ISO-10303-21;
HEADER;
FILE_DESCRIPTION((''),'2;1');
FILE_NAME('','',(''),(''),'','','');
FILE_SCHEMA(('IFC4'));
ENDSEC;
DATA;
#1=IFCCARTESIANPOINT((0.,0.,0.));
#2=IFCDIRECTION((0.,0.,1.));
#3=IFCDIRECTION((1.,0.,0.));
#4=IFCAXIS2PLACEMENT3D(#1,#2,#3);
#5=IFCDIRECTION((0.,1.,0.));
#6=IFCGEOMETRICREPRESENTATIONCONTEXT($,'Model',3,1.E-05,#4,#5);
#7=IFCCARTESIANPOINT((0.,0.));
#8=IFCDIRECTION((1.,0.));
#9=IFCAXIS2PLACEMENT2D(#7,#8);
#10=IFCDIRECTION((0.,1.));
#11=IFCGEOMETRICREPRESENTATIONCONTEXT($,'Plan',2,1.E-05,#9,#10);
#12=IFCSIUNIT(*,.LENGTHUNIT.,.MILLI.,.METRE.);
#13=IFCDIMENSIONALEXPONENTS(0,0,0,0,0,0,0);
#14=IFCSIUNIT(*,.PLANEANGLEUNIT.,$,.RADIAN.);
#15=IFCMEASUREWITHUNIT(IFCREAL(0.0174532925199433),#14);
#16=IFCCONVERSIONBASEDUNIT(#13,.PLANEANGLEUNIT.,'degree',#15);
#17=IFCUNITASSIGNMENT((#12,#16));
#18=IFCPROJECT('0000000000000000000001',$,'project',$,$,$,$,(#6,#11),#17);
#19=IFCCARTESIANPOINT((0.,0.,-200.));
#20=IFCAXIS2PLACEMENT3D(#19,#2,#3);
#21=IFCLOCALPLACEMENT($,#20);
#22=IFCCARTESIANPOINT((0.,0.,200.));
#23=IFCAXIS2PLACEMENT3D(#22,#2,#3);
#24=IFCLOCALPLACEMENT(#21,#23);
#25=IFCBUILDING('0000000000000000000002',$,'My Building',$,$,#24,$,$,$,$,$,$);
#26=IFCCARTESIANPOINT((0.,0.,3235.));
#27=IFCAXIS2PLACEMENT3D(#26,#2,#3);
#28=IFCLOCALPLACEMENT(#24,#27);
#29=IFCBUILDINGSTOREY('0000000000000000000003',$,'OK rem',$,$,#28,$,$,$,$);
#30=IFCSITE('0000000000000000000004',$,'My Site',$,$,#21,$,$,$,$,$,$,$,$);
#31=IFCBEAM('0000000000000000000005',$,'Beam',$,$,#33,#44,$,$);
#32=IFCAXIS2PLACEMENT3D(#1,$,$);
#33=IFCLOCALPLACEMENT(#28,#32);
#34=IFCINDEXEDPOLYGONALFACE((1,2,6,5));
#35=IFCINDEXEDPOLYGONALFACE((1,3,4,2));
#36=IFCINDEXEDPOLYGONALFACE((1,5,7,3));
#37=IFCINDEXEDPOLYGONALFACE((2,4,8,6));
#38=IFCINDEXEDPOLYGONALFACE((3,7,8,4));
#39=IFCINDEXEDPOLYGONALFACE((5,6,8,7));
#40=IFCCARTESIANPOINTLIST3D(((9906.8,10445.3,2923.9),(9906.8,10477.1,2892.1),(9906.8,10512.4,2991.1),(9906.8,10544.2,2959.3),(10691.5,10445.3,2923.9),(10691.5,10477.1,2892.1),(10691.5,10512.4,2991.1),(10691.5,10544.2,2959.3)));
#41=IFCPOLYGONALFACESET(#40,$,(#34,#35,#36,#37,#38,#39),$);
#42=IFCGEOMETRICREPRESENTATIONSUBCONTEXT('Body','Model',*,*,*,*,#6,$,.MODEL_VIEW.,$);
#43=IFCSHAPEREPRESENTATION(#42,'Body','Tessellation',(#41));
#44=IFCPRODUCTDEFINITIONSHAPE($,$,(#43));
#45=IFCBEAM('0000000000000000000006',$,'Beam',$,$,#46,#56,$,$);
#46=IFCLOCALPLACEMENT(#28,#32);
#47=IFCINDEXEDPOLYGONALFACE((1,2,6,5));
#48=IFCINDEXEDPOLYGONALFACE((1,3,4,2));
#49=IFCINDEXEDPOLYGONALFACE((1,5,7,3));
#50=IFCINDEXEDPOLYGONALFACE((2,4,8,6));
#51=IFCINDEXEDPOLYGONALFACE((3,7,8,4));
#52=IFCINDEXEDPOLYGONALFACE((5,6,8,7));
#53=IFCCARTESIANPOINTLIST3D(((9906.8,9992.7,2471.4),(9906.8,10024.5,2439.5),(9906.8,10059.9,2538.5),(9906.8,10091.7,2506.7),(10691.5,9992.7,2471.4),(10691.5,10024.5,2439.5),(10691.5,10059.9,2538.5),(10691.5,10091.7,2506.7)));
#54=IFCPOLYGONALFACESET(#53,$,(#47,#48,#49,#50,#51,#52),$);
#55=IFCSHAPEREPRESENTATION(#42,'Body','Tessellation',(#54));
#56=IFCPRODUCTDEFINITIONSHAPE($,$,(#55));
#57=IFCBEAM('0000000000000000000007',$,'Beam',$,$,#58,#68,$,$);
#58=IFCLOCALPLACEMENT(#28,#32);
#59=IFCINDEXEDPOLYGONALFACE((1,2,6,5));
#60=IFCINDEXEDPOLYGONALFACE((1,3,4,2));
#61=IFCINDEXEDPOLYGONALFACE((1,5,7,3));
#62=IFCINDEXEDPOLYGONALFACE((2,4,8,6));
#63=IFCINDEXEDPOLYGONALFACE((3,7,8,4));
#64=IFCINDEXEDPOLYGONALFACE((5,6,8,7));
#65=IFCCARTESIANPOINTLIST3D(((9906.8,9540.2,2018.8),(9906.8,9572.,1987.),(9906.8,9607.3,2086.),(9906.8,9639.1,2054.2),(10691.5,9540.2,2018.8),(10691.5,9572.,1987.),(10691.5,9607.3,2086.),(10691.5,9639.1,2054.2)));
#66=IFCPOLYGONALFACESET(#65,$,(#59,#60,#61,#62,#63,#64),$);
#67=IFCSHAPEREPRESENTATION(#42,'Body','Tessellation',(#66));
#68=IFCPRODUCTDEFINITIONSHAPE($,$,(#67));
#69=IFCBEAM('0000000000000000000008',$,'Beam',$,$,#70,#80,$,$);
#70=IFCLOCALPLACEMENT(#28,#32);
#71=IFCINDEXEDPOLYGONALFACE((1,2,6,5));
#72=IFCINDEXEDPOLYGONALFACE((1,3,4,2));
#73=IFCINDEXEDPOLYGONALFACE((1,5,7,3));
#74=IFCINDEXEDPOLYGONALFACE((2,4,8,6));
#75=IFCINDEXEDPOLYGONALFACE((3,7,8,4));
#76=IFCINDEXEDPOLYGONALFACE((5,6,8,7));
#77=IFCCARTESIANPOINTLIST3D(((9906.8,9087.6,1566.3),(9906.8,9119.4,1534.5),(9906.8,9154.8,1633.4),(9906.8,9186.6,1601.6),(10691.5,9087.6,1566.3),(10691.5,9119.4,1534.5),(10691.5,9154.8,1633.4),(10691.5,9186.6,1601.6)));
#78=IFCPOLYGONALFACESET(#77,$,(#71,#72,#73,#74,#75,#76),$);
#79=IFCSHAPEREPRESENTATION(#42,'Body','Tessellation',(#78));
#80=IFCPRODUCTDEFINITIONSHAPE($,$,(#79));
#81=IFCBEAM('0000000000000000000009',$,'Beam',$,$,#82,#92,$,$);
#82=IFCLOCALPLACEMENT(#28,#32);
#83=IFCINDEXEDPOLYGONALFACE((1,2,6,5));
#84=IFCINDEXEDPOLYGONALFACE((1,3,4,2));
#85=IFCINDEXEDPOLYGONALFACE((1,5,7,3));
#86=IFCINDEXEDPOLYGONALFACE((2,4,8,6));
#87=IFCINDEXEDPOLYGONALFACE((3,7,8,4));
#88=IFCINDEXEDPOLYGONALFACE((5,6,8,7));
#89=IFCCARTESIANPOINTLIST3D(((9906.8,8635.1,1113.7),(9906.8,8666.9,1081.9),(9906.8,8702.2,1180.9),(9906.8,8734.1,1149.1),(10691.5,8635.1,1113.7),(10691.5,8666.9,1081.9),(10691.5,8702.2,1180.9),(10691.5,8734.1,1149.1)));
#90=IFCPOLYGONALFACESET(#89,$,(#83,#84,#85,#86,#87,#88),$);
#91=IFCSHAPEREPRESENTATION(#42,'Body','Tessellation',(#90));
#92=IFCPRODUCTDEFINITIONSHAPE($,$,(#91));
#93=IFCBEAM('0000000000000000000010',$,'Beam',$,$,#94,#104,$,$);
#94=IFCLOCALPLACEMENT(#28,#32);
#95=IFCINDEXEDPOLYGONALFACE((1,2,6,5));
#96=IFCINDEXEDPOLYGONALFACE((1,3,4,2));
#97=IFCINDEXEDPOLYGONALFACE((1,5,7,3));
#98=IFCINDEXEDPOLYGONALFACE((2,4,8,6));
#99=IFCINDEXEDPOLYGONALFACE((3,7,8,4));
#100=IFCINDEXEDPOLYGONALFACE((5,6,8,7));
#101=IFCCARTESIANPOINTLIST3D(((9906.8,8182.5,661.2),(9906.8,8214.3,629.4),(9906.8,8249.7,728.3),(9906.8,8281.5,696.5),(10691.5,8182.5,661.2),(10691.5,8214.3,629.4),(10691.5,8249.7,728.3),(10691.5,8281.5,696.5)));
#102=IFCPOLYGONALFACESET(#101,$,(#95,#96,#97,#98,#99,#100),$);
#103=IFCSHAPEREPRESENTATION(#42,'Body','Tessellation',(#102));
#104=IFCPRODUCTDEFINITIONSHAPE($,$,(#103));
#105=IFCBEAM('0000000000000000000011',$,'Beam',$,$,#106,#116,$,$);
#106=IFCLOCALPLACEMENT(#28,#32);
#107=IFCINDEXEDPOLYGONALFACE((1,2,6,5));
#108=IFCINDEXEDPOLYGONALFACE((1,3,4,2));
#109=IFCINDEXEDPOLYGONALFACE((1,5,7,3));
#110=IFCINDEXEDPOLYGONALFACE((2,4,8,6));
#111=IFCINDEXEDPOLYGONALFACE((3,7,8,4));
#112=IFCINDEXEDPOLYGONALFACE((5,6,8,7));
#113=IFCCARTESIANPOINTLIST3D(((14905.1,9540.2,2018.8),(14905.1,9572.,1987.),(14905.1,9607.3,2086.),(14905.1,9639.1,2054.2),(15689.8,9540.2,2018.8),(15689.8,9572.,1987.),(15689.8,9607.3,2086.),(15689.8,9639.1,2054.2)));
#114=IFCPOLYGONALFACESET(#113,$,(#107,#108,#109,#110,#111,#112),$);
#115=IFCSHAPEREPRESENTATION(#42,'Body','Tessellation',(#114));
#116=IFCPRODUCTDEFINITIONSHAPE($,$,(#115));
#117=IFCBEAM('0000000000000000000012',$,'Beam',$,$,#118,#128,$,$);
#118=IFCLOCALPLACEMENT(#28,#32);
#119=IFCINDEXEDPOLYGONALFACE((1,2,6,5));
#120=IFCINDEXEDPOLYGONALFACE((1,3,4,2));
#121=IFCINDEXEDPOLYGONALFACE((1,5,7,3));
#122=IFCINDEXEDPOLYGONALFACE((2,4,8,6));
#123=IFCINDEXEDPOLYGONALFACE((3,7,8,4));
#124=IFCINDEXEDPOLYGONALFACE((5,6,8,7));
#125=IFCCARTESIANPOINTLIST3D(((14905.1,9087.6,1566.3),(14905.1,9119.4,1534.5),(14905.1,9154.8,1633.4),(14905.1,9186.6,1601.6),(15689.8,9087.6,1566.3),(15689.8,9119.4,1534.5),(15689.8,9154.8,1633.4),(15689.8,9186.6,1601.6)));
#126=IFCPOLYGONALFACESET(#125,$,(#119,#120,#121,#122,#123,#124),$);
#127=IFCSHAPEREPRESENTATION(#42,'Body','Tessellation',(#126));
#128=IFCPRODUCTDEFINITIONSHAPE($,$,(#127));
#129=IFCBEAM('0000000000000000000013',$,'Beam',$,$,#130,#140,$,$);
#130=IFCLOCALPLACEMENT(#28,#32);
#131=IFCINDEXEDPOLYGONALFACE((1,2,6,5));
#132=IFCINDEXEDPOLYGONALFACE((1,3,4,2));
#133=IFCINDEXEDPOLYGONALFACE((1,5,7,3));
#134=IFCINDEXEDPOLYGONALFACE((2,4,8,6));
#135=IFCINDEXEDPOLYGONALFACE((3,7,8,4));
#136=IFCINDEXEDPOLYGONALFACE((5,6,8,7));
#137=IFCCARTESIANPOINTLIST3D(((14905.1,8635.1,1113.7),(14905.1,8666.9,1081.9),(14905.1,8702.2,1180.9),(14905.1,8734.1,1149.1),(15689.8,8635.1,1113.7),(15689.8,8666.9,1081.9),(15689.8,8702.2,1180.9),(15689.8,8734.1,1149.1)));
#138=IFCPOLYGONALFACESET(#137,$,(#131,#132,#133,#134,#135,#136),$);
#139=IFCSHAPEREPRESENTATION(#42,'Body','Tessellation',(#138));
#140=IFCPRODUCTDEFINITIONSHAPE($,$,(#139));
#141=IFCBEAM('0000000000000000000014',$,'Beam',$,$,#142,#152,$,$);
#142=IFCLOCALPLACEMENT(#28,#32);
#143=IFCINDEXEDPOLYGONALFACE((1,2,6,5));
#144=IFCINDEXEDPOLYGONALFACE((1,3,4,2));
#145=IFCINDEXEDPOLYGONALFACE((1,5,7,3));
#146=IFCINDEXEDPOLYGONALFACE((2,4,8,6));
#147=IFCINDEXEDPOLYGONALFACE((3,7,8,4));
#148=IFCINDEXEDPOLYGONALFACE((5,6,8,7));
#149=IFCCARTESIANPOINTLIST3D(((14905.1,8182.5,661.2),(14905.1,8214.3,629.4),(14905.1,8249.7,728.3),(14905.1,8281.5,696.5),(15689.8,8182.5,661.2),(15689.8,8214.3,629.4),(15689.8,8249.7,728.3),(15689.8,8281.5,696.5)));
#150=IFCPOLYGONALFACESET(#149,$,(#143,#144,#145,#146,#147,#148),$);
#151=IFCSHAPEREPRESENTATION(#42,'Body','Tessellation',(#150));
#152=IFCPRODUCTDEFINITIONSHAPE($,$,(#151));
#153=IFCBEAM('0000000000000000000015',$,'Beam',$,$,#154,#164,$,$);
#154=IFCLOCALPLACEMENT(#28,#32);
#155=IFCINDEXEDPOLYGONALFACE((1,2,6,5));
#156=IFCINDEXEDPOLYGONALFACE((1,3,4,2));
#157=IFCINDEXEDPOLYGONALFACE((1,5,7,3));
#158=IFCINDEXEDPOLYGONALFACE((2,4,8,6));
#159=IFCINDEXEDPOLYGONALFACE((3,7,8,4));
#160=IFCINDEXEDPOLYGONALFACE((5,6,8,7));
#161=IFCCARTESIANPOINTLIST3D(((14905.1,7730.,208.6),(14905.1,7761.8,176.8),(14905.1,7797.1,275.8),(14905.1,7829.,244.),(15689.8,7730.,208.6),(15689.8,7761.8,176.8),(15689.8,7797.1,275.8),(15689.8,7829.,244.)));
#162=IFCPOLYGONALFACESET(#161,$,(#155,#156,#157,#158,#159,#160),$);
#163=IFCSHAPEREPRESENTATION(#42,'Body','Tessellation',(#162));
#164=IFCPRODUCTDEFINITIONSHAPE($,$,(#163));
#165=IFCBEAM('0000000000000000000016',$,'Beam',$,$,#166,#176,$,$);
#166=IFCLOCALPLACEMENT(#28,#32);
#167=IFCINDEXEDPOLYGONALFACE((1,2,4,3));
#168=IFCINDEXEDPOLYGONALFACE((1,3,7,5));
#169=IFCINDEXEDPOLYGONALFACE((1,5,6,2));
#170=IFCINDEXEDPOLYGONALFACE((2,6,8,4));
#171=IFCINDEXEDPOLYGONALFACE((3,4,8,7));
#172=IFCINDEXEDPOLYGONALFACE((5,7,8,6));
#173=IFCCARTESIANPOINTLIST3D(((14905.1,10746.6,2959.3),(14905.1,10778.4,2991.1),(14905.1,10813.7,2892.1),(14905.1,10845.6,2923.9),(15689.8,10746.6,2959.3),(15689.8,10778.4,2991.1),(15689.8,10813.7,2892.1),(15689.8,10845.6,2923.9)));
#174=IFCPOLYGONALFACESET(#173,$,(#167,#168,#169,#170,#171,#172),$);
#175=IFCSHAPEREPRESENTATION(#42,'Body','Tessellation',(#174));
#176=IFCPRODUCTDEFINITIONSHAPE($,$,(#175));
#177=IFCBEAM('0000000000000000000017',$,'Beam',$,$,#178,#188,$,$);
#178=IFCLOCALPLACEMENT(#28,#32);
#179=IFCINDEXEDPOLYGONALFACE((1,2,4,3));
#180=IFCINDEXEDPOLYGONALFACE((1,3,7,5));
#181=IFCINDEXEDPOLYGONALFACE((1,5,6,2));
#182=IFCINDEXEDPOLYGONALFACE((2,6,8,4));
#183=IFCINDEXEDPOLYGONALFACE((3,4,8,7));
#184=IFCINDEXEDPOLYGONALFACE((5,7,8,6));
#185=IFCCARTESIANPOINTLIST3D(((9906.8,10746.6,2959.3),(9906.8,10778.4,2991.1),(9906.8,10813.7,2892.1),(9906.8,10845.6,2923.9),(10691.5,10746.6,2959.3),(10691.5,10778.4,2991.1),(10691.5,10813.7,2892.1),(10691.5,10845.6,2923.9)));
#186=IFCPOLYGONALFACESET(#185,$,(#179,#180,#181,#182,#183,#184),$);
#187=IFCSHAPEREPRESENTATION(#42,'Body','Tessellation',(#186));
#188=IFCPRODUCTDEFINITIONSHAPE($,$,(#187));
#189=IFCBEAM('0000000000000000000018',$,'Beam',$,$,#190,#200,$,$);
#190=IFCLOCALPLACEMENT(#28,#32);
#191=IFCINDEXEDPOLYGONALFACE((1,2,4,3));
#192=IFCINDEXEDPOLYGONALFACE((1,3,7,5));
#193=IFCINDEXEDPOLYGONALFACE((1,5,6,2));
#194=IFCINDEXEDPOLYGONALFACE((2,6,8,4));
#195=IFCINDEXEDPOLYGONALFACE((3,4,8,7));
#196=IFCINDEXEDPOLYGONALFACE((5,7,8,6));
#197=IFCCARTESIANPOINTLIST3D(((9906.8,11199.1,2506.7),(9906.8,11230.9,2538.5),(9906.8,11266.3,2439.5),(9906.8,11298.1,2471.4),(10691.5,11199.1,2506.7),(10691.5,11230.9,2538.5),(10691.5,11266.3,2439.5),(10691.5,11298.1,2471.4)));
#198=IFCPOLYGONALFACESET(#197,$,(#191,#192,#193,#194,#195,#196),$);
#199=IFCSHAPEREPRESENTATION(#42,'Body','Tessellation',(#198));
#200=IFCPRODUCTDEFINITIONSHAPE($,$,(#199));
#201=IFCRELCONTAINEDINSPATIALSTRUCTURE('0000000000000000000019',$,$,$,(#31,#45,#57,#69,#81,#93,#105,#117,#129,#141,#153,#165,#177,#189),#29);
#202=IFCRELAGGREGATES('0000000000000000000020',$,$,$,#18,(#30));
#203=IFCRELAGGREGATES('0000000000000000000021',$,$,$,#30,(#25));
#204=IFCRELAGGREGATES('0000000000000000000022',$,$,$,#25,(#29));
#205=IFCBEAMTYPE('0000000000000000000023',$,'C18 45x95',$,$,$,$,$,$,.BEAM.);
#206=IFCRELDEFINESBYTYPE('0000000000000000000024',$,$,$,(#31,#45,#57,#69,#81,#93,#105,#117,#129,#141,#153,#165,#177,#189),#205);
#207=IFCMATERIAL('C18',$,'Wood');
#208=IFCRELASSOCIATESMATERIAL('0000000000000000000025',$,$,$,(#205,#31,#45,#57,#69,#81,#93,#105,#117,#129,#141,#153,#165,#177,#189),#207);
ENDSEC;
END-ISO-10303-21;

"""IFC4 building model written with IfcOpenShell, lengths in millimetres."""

from ifc_helpers import new_model, entity, si_unit, converted_unit, direction, frame, origin_with_axes, origin_2d_with_axis, place, context, subcontext, project, spatial, rectangle, extrude, material, material_profile, profile_set, profile_usage, type_object, element, save


model = new_model("IFC4")

# Units and contexts
model_context = context("Model", 3, precision=1e-05, world=origin_with_axes(), true_north=direction((0.0, 1.0, 0.0)))
plan_context = context("Plan", 2, precision=1e-05, world=origin_2d_with_axis(), true_north=direction((0.0, 1.0)))
body_context = subcontext(model_context, "Body", "Model", "MODEL_VIEW")
ifc_project = project(units=[si_unit("LENGTHUNIT", "METRE", prefix="MILLI"), converted_unit("PLANEANGLEUNIT", "degree", entity("IfcReal", 0.0174532925199433), si_unit("PLANEANGLEUNIT", "RADIAN"), dimensions=[0, 0, 0, 0, 0, 0, 0])], contexts=[model_context, plan_context])

# Site, building, storey
site_placement = place(None, frame((0.0, 0.0, -200.0), z_axis=(0.0, 0.0, 1.0), x_axis=(1.0, 0.0, 0.0)))
site = spatial("IfcSite", under=ifc_project, at=site_placement, Name="My Site")
building_placement = place(site_placement, frame((0.0, 0.0, 200.0), z_axis=(0.0, 0.0, 1.0), x_axis=(1.0, 0.0, 0.0)))
building = spatial("IfcBuilding", under=site, at=building_placement, Name="My Building")
storey_placement = place(building_placement, frame((0.0, 0.0, 3235.0), z_axis=(0.0, 0.0, 1.0), x_axis=(1.0, 0.0, 0.0)))
storey = spatial("IfcBuildingStorey", under=building, at=storey_placement, Name="OK rem")

# Beams
ifc_material = material(Name="C18", Category="Wood")
ifc_material_profile_1 = material_profile(ifc_material, rectangle(XDim=45.0, YDim=95.0))
ifc_profile_set_1 = profile_set([ifc_material_profile_1], Name="woodStructural")
ifc_profile_usage_1 = profile_usage(ifc_profile_set_1, cardinal=5)
beam_type_1 = type_object("IfcBeamType", Name="C18 45x95", PredefinedType="BEAM", material=ifc_profile_set_1)
beam_1_placement = place(storey_placement, frame((9906.8, 10494.7, 2941.6), z_axis=(1.0, 0.0, 0.0), x_axis=(0.0, 0.707107, -0.707107)))
element("IfcBeam", 1, at=beam_1_placement, inside=storey, type_object=beam_type_1, material=ifc_profile_usage_1, Name="Beam", context=body_context, shape_type="SweptSolid", body=[
    extrude(rectangle(XDim=45.0, YDim=95.0), origin_with_axes(), (0.0, 0.0, 1.0), 784.6),
])
ifc_profile_usage_2 = profile_usage(ifc_profile_set_1, cardinal=5)
beam_2_placement = place(storey_placement, frame((9906.8, 10042.2, 2489.0), z_axis=(1.0, 0.0, 0.0), x_axis=(0.0, 0.707107, -0.707107)))
element("IfcBeam", 2, at=beam_2_placement, inside=storey, type_object=beam_type_1, material=ifc_profile_usage_2, Name="Beam", context=body_context, shape_type="SweptSolid", body=[
    extrude(rectangle(XDim=45.0, YDim=95.0), origin_with_axes(), (0.0, 0.0, 1.0), 784.6),
])
ifc_profile_usage_3 = profile_usage(ifc_profile_set_1, cardinal=5)
beam_3_placement = place(storey_placement, frame((9906.8, 9589.7, 2036.5), z_axis=(1.0, 0.0, 0.0), x_axis=(0.0, 0.707107, -0.707107)))
element("IfcBeam", 3, at=beam_3_placement, inside=storey, type_object=beam_type_1, material=ifc_profile_usage_3, Name="Beam", context=body_context, shape_type="SweptSolid", body=[
    extrude(rectangle(XDim=45.0, YDim=95.0), origin_with_axes(), (0.0, 0.0, 1.0), 784.6),
])
ifc_profile_usage_4 = profile_usage(ifc_profile_set_1, cardinal=5)
beam_4_placement = place(storey_placement, frame((9906.8, 9137.1, 1583.9), z_axis=(1.0, 0.0, 0.0), x_axis=(0.0, 0.707107, -0.707107)))
element("IfcBeam", 4, at=beam_4_placement, inside=storey, type_object=beam_type_1, material=ifc_profile_usage_4, Name="Beam", context=body_context, shape_type="SweptSolid", body=[
    extrude(rectangle(XDim=45.0, YDim=95.0), origin_with_axes(), (0.0, 0.0, 1.0), 784.6),
])
ifc_profile_usage_5 = profile_usage(ifc_profile_set_1, cardinal=5)
beam_5_placement = place(storey_placement, frame((9906.8, 8684.6, 1131.4), z_axis=(1.0, 0.0, 0.0), x_axis=(0.0, 0.707107, -0.707107)))
element("IfcBeam", 5, at=beam_5_placement, inside=storey, type_object=beam_type_1, material=ifc_profile_usage_5, Name="Beam", context=body_context, shape_type="SweptSolid", body=[
    extrude(rectangle(XDim=45.0, YDim=95.0), origin_with_axes(), (0.0, 0.0, 1.0), 784.6),
])
ifc_profile_usage_6 = profile_usage(ifc_profile_set_1, cardinal=5)
beam_6_placement = place(storey_placement, frame((9906.8, 8232.0, 678.9), z_axis=(1.0, 0.0, 0.0), x_axis=(0.0, 0.707107, -0.707107)))
element("IfcBeam", 6, at=beam_6_placement, inside=storey, type_object=beam_type_1, material=ifc_profile_usage_6, Name="Beam", context=body_context, shape_type="SweptSolid", body=[
    extrude(rectangle(XDim=45.0, YDim=95.0), origin_with_axes(), (0.0, 0.0, 1.0), 784.6),
])
ifc_profile_usage_7 = profile_usage(ifc_profile_set_1, cardinal=5)
beam_7_placement = place(storey_placement, frame((14905.1, 9589.7, 2036.5), z_axis=(1.0, 0.0, 0.0), x_axis=(0.0, 0.707107, -0.707107)))
element("IfcBeam", 7, at=beam_7_placement, inside=storey, type_object=beam_type_1, material=ifc_profile_usage_7, Name="Beam", context=body_context, shape_type="SweptSolid", body=[
    extrude(rectangle(XDim=45.0, YDim=95.0), origin_with_axes(), (0.0, 0.0, 1.0), 784.6),
])
ifc_profile_usage_8 = profile_usage(ifc_profile_set_1, cardinal=5)
beam_8_placement = place(storey_placement, frame((14905.1, 9137.1, 1583.9), z_axis=(1.0, 0.0, 0.0), x_axis=(0.0, 0.707107, -0.707107)))
element("IfcBeam", 8, at=beam_8_placement, inside=storey, type_object=beam_type_1, material=ifc_profile_usage_8, Name="Beam", context=body_context, shape_type="SweptSolid", body=[
    extrude(rectangle(XDim=45.0, YDim=95.0), origin_with_axes(), (0.0, 0.0, 1.0), 784.6),
])
ifc_profile_usage_9 = profile_usage(ifc_profile_set_1, cardinal=5)
beam_9_placement = place(storey_placement, frame((14905.1, 8684.6, 1131.4), z_axis=(1.0, 0.0, 0.0), x_axis=(0.0, 0.707107, -0.707107)))
element("IfcBeam", 9, at=beam_9_placement, inside=storey, type_object=beam_type_1, material=ifc_profile_usage_9, Name="Beam", context=body_context, shape_type="SweptSolid", body=[
    extrude(rectangle(XDim=45.0, YDim=95.0), origin_with_axes(), (0.0, 0.0, 1.0), 784.6),
])
ifc_profile_usage_10 = profile_usage(ifc_profile_set_1, cardinal=5)
beam_10_placement = place(storey_placement, frame((14905.1, 8232.0, 678.9), z_axis=(1.0, 0.0, 0.0), x_axis=(0.0, 0.707107, -0.707107)))
element("IfcBeam", 10, at=beam_10_placement, inside=storey, type_object=beam_type_1, material=ifc_profile_usage_10, Name="Beam", context=body_context, shape_type="SweptSolid", body=[
    extrude(rectangle(XDim=45.0, YDim=95.0), origin_with_axes(), (0.0, 0.0, 1.0), 784.6),
])
ifc_profile_usage_11 = profile_usage(ifc_profile_set_1, cardinal=5)
beam_11_placement = place(storey_placement, frame((14905.1, 7779.5, 226.3), z_axis=(1.0, 0.0, 0.0), x_axis=(0.0, 0.707107, -0.707107)))
element("IfcBeam", 11, at=beam_11_placement, inside=storey, type_object=beam_type_1, material=ifc_profile_usage_11, Name="Beam", context=body_context, shape_type="SweptSolid", body=[
    extrude(rectangle(XDim=45.0, YDim=95.0), origin_with_axes(), (0.0, 0.0, 1.0), 784.6),
])
ifc_profile_usage_12 = profile_usage(ifc_profile_set_1, cardinal=5)
beam_12_placement = place(storey_placement, frame((14905.1, 10796.1, 2941.6), z_axis=(1.0, 0.0, 0.0), x_axis=(0.0, 0.707107, 0.707107)))
element("IfcBeam", 12, at=beam_12_placement, inside=storey, type_object=beam_type_1, material=ifc_profile_usage_12, Name="Beam", context=body_context, shape_type="SweptSolid", body=[
    extrude(rectangle(XDim=45.0, YDim=95.0), origin_with_axes(), (0.0, 0.0, 1.0), 784.6),
])
ifc_profile_usage_13 = profile_usage(ifc_profile_set_1, cardinal=5)
beam_13_placement = place(storey_placement, frame((9906.8, 10796.1, 2941.6), z_axis=(1.0, 0.0, 0.0), x_axis=(0.0, 0.707107, 0.707107)))
element("IfcBeam", 13, at=beam_13_placement, inside=storey, type_object=beam_type_1, material=ifc_profile_usage_13, Name="Beam", context=body_context, shape_type="SweptSolid", body=[
    extrude(rectangle(XDim=45.0, YDim=95.0), origin_with_axes(), (0.0, 0.0, 1.0), 784.6),
])
ifc_profile_usage_14 = profile_usage(ifc_profile_set_1, cardinal=5)
beam_14_placement = place(storey_placement, frame((9906.8, 11248.6, 2489.0), z_axis=(1.0, 0.0, 0.0), x_axis=(0.0, 0.707107, 0.707107)))
element("IfcBeam", 14, at=beam_14_placement, inside=storey, type_object=beam_type_1, material=ifc_profile_usage_14, Name="Beam", context=body_context, shape_type="SweptSolid", body=[
    extrude(rectangle(XDim=45.0, YDim=95.0), origin_with_axes(), (0.0, 0.0, 1.0), 784.6),
])

save(model, "model.ifc")
